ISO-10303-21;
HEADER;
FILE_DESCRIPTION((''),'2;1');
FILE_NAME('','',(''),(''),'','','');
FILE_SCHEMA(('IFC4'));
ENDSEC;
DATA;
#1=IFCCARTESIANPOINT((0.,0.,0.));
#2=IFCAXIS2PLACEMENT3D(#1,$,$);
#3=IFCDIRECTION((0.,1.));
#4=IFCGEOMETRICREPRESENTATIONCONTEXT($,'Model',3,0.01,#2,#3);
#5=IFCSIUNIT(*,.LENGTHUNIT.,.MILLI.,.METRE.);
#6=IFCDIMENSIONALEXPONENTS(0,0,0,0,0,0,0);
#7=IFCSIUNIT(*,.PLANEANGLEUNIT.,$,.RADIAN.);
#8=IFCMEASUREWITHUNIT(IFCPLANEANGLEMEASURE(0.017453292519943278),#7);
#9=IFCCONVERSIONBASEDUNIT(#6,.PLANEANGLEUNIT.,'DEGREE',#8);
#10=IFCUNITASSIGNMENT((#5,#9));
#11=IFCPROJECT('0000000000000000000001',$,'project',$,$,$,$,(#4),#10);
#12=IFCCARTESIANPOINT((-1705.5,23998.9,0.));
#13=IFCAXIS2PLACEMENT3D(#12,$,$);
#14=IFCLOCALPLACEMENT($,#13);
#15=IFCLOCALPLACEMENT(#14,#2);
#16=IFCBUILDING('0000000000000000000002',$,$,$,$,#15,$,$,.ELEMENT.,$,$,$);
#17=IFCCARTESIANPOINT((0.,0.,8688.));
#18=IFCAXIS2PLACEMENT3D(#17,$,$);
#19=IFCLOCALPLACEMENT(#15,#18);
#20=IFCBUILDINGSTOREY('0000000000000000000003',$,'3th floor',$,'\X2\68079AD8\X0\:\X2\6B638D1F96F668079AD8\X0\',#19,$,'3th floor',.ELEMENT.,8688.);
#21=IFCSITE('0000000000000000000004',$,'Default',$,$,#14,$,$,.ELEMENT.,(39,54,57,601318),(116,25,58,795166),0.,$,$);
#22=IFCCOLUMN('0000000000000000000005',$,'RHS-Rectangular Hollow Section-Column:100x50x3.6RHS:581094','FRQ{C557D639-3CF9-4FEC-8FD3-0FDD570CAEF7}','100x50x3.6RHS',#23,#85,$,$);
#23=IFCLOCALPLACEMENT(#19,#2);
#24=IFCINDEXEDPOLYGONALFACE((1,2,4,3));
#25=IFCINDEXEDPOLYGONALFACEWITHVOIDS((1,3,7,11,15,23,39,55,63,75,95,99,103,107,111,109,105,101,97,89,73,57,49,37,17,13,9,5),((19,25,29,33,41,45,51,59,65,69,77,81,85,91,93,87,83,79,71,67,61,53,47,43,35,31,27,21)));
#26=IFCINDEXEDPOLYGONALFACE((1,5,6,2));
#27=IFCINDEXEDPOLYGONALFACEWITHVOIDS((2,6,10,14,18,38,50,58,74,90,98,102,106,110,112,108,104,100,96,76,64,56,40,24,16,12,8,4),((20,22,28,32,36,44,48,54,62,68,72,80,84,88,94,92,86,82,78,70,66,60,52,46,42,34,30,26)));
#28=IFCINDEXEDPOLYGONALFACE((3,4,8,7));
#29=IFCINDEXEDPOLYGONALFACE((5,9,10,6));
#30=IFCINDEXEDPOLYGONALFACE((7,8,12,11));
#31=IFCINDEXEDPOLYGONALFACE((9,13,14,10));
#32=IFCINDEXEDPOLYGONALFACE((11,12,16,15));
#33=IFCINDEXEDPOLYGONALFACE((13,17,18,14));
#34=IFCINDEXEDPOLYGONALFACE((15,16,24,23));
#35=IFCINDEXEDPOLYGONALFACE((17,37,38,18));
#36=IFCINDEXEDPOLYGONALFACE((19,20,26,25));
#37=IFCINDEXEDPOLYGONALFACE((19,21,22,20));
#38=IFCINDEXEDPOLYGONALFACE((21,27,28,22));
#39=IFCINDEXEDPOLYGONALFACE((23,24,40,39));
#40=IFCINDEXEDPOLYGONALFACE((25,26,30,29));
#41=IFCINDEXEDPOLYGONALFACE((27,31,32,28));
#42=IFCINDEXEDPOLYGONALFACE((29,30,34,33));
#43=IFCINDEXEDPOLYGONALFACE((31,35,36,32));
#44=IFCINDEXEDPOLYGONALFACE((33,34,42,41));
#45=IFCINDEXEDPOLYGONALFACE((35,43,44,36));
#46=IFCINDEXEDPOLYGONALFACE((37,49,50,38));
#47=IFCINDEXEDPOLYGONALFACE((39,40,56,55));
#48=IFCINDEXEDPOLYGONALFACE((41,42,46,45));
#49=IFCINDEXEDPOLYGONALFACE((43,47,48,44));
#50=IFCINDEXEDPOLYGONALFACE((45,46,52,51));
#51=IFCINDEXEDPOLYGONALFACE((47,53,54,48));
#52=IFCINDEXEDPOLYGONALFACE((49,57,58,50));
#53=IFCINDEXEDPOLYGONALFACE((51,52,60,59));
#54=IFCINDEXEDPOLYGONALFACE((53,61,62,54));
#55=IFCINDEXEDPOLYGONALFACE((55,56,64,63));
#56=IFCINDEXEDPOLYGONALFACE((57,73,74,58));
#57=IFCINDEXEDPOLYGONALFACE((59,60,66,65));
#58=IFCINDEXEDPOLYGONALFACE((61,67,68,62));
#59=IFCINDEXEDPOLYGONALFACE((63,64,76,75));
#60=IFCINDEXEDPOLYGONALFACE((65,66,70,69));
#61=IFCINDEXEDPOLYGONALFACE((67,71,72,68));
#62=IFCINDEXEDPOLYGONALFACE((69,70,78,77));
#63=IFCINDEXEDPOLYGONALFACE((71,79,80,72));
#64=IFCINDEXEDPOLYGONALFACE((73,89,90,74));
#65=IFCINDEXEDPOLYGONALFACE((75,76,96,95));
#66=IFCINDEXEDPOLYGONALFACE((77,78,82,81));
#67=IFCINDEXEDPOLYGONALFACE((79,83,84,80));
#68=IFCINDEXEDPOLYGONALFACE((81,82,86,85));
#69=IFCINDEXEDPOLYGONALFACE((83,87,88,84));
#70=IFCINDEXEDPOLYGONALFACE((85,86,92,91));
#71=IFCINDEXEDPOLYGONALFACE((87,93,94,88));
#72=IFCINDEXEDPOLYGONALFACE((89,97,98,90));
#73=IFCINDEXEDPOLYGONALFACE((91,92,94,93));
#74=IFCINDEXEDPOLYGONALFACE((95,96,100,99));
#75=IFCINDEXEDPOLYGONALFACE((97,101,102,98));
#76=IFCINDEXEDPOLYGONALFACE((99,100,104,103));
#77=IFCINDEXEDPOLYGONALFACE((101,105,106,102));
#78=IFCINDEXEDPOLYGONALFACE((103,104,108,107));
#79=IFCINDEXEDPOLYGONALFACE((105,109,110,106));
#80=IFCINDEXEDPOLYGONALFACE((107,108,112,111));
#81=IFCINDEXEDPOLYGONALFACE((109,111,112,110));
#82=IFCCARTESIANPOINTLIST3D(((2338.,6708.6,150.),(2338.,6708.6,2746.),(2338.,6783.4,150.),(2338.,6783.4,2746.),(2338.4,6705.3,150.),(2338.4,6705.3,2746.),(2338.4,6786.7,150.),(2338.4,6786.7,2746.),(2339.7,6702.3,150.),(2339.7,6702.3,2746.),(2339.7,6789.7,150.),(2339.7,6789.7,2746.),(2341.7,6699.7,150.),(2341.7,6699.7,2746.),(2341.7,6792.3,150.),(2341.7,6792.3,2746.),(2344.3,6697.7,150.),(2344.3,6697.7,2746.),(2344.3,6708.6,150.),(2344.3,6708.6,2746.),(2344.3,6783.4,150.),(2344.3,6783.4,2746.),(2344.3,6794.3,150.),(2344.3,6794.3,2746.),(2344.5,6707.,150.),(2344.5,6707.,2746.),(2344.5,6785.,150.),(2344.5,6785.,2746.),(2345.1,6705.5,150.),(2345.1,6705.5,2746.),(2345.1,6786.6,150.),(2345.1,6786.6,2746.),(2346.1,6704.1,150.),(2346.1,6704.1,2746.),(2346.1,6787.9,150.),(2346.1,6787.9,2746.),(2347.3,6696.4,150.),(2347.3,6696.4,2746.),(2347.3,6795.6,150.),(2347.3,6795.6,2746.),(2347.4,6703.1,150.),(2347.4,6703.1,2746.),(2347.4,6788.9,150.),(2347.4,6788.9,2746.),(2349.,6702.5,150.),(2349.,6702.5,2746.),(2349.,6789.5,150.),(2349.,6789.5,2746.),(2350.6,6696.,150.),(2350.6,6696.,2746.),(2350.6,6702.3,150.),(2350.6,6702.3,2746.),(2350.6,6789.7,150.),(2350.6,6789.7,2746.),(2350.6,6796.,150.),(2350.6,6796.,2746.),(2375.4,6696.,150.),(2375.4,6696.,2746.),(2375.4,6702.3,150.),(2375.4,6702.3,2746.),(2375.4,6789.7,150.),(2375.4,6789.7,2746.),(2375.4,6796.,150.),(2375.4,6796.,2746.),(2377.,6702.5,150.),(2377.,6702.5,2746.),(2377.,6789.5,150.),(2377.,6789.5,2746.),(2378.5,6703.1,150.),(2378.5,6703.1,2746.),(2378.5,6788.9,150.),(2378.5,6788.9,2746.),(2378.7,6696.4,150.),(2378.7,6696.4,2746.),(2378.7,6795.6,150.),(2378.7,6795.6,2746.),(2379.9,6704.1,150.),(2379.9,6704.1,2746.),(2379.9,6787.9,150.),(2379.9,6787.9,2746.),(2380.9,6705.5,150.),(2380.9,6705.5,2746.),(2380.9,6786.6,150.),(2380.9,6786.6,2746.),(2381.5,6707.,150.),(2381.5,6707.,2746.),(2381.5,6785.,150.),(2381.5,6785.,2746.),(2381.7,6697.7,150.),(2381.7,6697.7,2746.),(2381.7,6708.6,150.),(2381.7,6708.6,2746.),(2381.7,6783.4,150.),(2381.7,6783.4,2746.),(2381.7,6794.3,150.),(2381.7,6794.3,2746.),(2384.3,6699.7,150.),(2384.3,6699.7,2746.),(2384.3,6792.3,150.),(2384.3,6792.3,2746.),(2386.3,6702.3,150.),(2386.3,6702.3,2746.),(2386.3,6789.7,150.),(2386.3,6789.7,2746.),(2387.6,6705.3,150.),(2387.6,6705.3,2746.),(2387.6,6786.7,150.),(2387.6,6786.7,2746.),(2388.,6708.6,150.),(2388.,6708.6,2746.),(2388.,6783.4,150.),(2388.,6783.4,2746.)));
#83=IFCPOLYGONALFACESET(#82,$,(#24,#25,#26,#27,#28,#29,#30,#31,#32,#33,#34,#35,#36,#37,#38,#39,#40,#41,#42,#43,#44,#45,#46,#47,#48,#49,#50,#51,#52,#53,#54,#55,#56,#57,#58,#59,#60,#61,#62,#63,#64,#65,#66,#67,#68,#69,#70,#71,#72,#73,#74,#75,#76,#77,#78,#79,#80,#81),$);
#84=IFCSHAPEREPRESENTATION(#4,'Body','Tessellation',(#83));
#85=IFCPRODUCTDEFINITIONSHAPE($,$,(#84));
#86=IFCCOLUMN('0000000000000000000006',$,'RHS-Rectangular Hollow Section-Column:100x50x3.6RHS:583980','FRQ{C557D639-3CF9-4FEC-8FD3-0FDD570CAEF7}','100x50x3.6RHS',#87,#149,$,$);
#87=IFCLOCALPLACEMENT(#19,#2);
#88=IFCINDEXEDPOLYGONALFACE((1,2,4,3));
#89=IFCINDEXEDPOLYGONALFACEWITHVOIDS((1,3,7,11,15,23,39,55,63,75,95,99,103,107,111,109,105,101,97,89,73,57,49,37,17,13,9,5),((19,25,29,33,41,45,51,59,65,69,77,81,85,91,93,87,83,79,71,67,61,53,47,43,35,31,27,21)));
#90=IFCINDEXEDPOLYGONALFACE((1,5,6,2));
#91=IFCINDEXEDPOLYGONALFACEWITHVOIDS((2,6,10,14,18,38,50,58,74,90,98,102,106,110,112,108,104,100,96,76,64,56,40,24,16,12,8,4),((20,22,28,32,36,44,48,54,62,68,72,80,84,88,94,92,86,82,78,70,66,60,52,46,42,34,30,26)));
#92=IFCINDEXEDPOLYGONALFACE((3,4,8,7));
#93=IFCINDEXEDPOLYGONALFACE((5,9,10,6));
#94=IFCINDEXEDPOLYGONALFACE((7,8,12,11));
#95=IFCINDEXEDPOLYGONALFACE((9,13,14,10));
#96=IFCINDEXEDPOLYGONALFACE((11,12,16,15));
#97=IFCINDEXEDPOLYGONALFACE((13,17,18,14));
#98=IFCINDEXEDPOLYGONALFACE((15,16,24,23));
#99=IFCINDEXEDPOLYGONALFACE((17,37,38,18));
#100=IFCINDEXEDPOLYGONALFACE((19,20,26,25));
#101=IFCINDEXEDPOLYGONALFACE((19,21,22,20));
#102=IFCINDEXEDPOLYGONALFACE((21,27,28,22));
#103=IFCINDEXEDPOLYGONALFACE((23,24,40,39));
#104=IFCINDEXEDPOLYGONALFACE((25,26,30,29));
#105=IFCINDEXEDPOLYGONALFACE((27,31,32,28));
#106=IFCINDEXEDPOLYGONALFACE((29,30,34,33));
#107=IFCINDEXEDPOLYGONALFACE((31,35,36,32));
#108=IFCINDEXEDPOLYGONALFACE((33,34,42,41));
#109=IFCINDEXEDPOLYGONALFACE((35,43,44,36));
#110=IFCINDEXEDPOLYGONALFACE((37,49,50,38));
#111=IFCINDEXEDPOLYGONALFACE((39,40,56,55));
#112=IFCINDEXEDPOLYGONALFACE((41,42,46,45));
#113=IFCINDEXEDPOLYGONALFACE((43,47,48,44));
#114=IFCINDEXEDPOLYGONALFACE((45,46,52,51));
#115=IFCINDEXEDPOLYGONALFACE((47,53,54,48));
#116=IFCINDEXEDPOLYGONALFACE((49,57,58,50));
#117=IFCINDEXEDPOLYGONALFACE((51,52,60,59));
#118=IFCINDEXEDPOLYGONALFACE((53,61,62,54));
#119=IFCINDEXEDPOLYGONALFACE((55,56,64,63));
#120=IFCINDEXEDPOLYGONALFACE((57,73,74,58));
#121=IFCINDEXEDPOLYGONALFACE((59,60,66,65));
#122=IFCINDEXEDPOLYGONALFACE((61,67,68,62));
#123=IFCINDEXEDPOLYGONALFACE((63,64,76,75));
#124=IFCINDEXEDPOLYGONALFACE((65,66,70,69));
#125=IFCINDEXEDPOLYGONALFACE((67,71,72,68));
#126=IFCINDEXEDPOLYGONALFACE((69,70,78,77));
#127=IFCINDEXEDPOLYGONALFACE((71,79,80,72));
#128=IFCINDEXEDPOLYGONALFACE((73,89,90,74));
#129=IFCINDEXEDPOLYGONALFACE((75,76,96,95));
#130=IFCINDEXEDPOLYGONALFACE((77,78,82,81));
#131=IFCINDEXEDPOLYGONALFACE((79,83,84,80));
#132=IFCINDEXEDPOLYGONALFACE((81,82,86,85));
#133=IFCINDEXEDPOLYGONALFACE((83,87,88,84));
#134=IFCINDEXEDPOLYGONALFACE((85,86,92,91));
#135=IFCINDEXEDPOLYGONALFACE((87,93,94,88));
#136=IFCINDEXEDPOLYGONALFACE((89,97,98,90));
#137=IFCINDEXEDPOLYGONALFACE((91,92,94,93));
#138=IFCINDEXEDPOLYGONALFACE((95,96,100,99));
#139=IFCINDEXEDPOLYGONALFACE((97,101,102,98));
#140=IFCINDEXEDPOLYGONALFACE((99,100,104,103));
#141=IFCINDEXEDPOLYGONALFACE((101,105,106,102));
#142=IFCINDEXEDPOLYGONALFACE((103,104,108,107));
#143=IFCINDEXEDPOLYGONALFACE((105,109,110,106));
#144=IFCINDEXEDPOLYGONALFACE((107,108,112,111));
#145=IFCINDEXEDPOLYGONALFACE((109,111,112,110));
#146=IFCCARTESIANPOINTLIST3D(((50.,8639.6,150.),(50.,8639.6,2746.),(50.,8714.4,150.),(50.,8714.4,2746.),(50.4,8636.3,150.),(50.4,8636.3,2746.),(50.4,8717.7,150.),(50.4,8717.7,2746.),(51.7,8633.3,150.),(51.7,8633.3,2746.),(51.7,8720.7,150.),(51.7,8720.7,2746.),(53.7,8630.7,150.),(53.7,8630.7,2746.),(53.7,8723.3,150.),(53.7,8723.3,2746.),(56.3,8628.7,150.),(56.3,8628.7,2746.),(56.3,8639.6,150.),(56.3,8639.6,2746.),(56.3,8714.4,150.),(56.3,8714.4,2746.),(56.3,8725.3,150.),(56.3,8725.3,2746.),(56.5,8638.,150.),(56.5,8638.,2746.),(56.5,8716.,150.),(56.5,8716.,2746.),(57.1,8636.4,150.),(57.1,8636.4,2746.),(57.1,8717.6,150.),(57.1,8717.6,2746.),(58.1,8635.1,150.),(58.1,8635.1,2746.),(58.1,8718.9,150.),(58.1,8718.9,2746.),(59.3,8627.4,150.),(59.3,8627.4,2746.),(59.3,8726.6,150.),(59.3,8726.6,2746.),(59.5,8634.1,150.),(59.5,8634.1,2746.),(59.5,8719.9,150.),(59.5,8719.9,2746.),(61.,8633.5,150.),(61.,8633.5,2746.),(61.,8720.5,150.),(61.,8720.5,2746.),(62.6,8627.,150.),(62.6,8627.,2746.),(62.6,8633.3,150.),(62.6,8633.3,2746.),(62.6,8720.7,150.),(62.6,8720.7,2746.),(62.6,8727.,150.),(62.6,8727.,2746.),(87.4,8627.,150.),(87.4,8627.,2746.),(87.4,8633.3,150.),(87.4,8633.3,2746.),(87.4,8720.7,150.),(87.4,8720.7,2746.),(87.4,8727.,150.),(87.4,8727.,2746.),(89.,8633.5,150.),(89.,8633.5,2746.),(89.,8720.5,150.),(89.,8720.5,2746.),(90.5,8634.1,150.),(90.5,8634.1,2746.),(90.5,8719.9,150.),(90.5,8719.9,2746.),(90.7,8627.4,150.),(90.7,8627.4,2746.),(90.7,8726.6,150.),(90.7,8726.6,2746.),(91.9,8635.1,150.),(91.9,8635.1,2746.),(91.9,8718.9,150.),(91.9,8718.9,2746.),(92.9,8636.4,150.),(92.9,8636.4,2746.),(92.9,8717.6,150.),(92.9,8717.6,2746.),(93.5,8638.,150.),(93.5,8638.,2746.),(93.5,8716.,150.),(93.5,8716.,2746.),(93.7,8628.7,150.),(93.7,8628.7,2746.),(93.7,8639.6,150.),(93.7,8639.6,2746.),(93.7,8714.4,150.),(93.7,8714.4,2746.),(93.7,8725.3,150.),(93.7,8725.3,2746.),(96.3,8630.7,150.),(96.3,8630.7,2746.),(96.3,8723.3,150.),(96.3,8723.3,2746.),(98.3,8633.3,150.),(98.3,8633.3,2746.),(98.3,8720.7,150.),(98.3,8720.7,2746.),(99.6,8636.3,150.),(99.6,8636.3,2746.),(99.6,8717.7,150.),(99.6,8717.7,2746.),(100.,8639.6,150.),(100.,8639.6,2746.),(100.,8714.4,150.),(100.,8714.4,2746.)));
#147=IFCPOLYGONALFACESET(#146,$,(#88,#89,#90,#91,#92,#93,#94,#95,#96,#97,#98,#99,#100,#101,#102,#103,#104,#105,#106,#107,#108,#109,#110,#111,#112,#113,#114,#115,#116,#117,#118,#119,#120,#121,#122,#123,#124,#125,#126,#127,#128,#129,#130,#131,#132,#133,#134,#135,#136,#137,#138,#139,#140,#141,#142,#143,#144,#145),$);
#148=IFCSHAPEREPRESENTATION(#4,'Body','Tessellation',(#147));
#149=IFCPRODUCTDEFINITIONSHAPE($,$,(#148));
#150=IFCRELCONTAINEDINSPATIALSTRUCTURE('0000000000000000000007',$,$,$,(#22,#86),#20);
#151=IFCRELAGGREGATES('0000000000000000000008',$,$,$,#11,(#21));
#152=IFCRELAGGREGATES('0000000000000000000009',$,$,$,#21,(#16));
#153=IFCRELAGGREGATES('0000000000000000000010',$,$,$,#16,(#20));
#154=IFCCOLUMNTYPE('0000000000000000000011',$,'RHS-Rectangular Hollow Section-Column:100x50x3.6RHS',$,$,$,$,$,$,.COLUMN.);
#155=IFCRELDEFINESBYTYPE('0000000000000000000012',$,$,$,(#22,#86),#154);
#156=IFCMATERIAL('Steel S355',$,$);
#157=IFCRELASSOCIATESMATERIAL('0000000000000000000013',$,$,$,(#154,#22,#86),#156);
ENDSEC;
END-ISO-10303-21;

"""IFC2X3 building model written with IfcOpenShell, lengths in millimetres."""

from ifc_helpers import new_model, entity, si_unit, converted_unit, direction, frame, origin, origin_2d, place, context, project, spatial, hollow_rectangle, extrude, clip, halfspace, material, type_object, element, save


model = new_model("IFC2X3")

# Units and contexts
model_context = context("Model", 3, precision=0.01, world=origin(), true_north=direction((0.0, 1.0)))
ifc_project = project(units=[si_unit("LENGTHUNIT", "METRE", prefix="MILLI"), converted_unit("PLANEANGLEUNIT", "DEGREE", entity("IfcPlaneAngleMeasure", 0.017453292519943278), si_unit("PLANEANGLEUNIT", "RADIAN"), dimensions=[0, 0, 0, 0, 0, 0, 0])], contexts=[model_context])

# Site, building, storey
site_placement = place(None, frame((-1705.5, 23998.9, 0.0)))
site = spatial("IfcSite", under=ifc_project, at=site_placement, Name="Default", CompositionType="ELEMENT", RefLatitude=(39, 54, 57, 601318), RefLongitude=(116, 25, 58, 795166), RefElevation=0.0)
building_placement = place(site_placement, origin())
building = spatial("IfcBuilding", under=site, at=building_placement, CompositionType="ELEMENT")
storey_placement = place(building_placement, frame((0.0, 0.0, 8688.0)))
storey = spatial("IfcBuildingStorey", under=building, at=storey_placement, Name="3th floor", ObjectType="标高:正负零标高", LongName="3th floor", CompositionType="ELEMENT", Elevation=8688.0)

# Columns
ifc_material_1 = material(Name="Steel S355")
column_type = type_object("IfcColumnType", Name="RHS-Rectangular Hollow Section-Column:100x50x3.6RHS", PredefinedType="COLUMN", material=ifc_material_1)
column_1_placement = place(storey_placement, frame((2363.0, 6746.0, 2746.0), z_axis=(0.0, 0.0, 1.0), x_axis=(-1.0, 0.0, 0.0)))
element("IfcColumn", 1, at=column_1_placement, inside=storey, type_object=column_type, material=ifc_material_1, Name="RHS-Rectangular Hollow Section-Column:100x50x3.6RHS:581094", Description="FRQ{C557D639-3CF9-4FEC-8FD3-0FDD570CAEF7}", ObjectType="100x50x3.6RHS", context=model_context, shape_type="Clipping", body=[
    clip(extrude(hollow_rectangle(XDim=50.0, YDim=100.0, WallThickness=6.3, InnerFilletRadius=6.3, OuterFilletRadius=12.6, at=origin_2d()), origin(), (0.0, 0.0, -1.0), 2651.9), halfspace(frame((2363.0, 6746.0, -2596.0), z_axis=(0.0, 0.0, 1.0), x_axis=(-1.0, 0.0, 0.0)), True)),
])
column_2_placement = place(storey_placement, frame((75.0, 8677.0, 2746.0), z_axis=(0.0, 0.0, 1.0), x_axis=(-1.0, 0.0, 0.0)))
element("IfcColumn", 2, at=column_2_placement, inside=storey, type_object=column_type, material=ifc_material_1, Name="RHS-Rectangular Hollow Section-Column:100x50x3.6RHS:583980", Description="FRQ{C557D639-3CF9-4FEC-8FD3-0FDD570CAEF7}", ObjectType="100x50x3.6RHS", context=model_context, shape_type="Clipping", body=[
    clip(extrude(hollow_rectangle(XDim=50.0, YDim=100.0, WallThickness=6.3, InnerFilletRadius=6.3, OuterFilletRadius=12.6, at=origin_2d()), origin(), (0.0, 0.0, -1.0), 2651.9), halfspace(frame((75.0, 8677.0, -2596.0), z_axis=(0.0, 0.0, 1.0), x_axis=(-1.0, 0.0, 0.0)), True)),
])

save(model, "model.ifc")
